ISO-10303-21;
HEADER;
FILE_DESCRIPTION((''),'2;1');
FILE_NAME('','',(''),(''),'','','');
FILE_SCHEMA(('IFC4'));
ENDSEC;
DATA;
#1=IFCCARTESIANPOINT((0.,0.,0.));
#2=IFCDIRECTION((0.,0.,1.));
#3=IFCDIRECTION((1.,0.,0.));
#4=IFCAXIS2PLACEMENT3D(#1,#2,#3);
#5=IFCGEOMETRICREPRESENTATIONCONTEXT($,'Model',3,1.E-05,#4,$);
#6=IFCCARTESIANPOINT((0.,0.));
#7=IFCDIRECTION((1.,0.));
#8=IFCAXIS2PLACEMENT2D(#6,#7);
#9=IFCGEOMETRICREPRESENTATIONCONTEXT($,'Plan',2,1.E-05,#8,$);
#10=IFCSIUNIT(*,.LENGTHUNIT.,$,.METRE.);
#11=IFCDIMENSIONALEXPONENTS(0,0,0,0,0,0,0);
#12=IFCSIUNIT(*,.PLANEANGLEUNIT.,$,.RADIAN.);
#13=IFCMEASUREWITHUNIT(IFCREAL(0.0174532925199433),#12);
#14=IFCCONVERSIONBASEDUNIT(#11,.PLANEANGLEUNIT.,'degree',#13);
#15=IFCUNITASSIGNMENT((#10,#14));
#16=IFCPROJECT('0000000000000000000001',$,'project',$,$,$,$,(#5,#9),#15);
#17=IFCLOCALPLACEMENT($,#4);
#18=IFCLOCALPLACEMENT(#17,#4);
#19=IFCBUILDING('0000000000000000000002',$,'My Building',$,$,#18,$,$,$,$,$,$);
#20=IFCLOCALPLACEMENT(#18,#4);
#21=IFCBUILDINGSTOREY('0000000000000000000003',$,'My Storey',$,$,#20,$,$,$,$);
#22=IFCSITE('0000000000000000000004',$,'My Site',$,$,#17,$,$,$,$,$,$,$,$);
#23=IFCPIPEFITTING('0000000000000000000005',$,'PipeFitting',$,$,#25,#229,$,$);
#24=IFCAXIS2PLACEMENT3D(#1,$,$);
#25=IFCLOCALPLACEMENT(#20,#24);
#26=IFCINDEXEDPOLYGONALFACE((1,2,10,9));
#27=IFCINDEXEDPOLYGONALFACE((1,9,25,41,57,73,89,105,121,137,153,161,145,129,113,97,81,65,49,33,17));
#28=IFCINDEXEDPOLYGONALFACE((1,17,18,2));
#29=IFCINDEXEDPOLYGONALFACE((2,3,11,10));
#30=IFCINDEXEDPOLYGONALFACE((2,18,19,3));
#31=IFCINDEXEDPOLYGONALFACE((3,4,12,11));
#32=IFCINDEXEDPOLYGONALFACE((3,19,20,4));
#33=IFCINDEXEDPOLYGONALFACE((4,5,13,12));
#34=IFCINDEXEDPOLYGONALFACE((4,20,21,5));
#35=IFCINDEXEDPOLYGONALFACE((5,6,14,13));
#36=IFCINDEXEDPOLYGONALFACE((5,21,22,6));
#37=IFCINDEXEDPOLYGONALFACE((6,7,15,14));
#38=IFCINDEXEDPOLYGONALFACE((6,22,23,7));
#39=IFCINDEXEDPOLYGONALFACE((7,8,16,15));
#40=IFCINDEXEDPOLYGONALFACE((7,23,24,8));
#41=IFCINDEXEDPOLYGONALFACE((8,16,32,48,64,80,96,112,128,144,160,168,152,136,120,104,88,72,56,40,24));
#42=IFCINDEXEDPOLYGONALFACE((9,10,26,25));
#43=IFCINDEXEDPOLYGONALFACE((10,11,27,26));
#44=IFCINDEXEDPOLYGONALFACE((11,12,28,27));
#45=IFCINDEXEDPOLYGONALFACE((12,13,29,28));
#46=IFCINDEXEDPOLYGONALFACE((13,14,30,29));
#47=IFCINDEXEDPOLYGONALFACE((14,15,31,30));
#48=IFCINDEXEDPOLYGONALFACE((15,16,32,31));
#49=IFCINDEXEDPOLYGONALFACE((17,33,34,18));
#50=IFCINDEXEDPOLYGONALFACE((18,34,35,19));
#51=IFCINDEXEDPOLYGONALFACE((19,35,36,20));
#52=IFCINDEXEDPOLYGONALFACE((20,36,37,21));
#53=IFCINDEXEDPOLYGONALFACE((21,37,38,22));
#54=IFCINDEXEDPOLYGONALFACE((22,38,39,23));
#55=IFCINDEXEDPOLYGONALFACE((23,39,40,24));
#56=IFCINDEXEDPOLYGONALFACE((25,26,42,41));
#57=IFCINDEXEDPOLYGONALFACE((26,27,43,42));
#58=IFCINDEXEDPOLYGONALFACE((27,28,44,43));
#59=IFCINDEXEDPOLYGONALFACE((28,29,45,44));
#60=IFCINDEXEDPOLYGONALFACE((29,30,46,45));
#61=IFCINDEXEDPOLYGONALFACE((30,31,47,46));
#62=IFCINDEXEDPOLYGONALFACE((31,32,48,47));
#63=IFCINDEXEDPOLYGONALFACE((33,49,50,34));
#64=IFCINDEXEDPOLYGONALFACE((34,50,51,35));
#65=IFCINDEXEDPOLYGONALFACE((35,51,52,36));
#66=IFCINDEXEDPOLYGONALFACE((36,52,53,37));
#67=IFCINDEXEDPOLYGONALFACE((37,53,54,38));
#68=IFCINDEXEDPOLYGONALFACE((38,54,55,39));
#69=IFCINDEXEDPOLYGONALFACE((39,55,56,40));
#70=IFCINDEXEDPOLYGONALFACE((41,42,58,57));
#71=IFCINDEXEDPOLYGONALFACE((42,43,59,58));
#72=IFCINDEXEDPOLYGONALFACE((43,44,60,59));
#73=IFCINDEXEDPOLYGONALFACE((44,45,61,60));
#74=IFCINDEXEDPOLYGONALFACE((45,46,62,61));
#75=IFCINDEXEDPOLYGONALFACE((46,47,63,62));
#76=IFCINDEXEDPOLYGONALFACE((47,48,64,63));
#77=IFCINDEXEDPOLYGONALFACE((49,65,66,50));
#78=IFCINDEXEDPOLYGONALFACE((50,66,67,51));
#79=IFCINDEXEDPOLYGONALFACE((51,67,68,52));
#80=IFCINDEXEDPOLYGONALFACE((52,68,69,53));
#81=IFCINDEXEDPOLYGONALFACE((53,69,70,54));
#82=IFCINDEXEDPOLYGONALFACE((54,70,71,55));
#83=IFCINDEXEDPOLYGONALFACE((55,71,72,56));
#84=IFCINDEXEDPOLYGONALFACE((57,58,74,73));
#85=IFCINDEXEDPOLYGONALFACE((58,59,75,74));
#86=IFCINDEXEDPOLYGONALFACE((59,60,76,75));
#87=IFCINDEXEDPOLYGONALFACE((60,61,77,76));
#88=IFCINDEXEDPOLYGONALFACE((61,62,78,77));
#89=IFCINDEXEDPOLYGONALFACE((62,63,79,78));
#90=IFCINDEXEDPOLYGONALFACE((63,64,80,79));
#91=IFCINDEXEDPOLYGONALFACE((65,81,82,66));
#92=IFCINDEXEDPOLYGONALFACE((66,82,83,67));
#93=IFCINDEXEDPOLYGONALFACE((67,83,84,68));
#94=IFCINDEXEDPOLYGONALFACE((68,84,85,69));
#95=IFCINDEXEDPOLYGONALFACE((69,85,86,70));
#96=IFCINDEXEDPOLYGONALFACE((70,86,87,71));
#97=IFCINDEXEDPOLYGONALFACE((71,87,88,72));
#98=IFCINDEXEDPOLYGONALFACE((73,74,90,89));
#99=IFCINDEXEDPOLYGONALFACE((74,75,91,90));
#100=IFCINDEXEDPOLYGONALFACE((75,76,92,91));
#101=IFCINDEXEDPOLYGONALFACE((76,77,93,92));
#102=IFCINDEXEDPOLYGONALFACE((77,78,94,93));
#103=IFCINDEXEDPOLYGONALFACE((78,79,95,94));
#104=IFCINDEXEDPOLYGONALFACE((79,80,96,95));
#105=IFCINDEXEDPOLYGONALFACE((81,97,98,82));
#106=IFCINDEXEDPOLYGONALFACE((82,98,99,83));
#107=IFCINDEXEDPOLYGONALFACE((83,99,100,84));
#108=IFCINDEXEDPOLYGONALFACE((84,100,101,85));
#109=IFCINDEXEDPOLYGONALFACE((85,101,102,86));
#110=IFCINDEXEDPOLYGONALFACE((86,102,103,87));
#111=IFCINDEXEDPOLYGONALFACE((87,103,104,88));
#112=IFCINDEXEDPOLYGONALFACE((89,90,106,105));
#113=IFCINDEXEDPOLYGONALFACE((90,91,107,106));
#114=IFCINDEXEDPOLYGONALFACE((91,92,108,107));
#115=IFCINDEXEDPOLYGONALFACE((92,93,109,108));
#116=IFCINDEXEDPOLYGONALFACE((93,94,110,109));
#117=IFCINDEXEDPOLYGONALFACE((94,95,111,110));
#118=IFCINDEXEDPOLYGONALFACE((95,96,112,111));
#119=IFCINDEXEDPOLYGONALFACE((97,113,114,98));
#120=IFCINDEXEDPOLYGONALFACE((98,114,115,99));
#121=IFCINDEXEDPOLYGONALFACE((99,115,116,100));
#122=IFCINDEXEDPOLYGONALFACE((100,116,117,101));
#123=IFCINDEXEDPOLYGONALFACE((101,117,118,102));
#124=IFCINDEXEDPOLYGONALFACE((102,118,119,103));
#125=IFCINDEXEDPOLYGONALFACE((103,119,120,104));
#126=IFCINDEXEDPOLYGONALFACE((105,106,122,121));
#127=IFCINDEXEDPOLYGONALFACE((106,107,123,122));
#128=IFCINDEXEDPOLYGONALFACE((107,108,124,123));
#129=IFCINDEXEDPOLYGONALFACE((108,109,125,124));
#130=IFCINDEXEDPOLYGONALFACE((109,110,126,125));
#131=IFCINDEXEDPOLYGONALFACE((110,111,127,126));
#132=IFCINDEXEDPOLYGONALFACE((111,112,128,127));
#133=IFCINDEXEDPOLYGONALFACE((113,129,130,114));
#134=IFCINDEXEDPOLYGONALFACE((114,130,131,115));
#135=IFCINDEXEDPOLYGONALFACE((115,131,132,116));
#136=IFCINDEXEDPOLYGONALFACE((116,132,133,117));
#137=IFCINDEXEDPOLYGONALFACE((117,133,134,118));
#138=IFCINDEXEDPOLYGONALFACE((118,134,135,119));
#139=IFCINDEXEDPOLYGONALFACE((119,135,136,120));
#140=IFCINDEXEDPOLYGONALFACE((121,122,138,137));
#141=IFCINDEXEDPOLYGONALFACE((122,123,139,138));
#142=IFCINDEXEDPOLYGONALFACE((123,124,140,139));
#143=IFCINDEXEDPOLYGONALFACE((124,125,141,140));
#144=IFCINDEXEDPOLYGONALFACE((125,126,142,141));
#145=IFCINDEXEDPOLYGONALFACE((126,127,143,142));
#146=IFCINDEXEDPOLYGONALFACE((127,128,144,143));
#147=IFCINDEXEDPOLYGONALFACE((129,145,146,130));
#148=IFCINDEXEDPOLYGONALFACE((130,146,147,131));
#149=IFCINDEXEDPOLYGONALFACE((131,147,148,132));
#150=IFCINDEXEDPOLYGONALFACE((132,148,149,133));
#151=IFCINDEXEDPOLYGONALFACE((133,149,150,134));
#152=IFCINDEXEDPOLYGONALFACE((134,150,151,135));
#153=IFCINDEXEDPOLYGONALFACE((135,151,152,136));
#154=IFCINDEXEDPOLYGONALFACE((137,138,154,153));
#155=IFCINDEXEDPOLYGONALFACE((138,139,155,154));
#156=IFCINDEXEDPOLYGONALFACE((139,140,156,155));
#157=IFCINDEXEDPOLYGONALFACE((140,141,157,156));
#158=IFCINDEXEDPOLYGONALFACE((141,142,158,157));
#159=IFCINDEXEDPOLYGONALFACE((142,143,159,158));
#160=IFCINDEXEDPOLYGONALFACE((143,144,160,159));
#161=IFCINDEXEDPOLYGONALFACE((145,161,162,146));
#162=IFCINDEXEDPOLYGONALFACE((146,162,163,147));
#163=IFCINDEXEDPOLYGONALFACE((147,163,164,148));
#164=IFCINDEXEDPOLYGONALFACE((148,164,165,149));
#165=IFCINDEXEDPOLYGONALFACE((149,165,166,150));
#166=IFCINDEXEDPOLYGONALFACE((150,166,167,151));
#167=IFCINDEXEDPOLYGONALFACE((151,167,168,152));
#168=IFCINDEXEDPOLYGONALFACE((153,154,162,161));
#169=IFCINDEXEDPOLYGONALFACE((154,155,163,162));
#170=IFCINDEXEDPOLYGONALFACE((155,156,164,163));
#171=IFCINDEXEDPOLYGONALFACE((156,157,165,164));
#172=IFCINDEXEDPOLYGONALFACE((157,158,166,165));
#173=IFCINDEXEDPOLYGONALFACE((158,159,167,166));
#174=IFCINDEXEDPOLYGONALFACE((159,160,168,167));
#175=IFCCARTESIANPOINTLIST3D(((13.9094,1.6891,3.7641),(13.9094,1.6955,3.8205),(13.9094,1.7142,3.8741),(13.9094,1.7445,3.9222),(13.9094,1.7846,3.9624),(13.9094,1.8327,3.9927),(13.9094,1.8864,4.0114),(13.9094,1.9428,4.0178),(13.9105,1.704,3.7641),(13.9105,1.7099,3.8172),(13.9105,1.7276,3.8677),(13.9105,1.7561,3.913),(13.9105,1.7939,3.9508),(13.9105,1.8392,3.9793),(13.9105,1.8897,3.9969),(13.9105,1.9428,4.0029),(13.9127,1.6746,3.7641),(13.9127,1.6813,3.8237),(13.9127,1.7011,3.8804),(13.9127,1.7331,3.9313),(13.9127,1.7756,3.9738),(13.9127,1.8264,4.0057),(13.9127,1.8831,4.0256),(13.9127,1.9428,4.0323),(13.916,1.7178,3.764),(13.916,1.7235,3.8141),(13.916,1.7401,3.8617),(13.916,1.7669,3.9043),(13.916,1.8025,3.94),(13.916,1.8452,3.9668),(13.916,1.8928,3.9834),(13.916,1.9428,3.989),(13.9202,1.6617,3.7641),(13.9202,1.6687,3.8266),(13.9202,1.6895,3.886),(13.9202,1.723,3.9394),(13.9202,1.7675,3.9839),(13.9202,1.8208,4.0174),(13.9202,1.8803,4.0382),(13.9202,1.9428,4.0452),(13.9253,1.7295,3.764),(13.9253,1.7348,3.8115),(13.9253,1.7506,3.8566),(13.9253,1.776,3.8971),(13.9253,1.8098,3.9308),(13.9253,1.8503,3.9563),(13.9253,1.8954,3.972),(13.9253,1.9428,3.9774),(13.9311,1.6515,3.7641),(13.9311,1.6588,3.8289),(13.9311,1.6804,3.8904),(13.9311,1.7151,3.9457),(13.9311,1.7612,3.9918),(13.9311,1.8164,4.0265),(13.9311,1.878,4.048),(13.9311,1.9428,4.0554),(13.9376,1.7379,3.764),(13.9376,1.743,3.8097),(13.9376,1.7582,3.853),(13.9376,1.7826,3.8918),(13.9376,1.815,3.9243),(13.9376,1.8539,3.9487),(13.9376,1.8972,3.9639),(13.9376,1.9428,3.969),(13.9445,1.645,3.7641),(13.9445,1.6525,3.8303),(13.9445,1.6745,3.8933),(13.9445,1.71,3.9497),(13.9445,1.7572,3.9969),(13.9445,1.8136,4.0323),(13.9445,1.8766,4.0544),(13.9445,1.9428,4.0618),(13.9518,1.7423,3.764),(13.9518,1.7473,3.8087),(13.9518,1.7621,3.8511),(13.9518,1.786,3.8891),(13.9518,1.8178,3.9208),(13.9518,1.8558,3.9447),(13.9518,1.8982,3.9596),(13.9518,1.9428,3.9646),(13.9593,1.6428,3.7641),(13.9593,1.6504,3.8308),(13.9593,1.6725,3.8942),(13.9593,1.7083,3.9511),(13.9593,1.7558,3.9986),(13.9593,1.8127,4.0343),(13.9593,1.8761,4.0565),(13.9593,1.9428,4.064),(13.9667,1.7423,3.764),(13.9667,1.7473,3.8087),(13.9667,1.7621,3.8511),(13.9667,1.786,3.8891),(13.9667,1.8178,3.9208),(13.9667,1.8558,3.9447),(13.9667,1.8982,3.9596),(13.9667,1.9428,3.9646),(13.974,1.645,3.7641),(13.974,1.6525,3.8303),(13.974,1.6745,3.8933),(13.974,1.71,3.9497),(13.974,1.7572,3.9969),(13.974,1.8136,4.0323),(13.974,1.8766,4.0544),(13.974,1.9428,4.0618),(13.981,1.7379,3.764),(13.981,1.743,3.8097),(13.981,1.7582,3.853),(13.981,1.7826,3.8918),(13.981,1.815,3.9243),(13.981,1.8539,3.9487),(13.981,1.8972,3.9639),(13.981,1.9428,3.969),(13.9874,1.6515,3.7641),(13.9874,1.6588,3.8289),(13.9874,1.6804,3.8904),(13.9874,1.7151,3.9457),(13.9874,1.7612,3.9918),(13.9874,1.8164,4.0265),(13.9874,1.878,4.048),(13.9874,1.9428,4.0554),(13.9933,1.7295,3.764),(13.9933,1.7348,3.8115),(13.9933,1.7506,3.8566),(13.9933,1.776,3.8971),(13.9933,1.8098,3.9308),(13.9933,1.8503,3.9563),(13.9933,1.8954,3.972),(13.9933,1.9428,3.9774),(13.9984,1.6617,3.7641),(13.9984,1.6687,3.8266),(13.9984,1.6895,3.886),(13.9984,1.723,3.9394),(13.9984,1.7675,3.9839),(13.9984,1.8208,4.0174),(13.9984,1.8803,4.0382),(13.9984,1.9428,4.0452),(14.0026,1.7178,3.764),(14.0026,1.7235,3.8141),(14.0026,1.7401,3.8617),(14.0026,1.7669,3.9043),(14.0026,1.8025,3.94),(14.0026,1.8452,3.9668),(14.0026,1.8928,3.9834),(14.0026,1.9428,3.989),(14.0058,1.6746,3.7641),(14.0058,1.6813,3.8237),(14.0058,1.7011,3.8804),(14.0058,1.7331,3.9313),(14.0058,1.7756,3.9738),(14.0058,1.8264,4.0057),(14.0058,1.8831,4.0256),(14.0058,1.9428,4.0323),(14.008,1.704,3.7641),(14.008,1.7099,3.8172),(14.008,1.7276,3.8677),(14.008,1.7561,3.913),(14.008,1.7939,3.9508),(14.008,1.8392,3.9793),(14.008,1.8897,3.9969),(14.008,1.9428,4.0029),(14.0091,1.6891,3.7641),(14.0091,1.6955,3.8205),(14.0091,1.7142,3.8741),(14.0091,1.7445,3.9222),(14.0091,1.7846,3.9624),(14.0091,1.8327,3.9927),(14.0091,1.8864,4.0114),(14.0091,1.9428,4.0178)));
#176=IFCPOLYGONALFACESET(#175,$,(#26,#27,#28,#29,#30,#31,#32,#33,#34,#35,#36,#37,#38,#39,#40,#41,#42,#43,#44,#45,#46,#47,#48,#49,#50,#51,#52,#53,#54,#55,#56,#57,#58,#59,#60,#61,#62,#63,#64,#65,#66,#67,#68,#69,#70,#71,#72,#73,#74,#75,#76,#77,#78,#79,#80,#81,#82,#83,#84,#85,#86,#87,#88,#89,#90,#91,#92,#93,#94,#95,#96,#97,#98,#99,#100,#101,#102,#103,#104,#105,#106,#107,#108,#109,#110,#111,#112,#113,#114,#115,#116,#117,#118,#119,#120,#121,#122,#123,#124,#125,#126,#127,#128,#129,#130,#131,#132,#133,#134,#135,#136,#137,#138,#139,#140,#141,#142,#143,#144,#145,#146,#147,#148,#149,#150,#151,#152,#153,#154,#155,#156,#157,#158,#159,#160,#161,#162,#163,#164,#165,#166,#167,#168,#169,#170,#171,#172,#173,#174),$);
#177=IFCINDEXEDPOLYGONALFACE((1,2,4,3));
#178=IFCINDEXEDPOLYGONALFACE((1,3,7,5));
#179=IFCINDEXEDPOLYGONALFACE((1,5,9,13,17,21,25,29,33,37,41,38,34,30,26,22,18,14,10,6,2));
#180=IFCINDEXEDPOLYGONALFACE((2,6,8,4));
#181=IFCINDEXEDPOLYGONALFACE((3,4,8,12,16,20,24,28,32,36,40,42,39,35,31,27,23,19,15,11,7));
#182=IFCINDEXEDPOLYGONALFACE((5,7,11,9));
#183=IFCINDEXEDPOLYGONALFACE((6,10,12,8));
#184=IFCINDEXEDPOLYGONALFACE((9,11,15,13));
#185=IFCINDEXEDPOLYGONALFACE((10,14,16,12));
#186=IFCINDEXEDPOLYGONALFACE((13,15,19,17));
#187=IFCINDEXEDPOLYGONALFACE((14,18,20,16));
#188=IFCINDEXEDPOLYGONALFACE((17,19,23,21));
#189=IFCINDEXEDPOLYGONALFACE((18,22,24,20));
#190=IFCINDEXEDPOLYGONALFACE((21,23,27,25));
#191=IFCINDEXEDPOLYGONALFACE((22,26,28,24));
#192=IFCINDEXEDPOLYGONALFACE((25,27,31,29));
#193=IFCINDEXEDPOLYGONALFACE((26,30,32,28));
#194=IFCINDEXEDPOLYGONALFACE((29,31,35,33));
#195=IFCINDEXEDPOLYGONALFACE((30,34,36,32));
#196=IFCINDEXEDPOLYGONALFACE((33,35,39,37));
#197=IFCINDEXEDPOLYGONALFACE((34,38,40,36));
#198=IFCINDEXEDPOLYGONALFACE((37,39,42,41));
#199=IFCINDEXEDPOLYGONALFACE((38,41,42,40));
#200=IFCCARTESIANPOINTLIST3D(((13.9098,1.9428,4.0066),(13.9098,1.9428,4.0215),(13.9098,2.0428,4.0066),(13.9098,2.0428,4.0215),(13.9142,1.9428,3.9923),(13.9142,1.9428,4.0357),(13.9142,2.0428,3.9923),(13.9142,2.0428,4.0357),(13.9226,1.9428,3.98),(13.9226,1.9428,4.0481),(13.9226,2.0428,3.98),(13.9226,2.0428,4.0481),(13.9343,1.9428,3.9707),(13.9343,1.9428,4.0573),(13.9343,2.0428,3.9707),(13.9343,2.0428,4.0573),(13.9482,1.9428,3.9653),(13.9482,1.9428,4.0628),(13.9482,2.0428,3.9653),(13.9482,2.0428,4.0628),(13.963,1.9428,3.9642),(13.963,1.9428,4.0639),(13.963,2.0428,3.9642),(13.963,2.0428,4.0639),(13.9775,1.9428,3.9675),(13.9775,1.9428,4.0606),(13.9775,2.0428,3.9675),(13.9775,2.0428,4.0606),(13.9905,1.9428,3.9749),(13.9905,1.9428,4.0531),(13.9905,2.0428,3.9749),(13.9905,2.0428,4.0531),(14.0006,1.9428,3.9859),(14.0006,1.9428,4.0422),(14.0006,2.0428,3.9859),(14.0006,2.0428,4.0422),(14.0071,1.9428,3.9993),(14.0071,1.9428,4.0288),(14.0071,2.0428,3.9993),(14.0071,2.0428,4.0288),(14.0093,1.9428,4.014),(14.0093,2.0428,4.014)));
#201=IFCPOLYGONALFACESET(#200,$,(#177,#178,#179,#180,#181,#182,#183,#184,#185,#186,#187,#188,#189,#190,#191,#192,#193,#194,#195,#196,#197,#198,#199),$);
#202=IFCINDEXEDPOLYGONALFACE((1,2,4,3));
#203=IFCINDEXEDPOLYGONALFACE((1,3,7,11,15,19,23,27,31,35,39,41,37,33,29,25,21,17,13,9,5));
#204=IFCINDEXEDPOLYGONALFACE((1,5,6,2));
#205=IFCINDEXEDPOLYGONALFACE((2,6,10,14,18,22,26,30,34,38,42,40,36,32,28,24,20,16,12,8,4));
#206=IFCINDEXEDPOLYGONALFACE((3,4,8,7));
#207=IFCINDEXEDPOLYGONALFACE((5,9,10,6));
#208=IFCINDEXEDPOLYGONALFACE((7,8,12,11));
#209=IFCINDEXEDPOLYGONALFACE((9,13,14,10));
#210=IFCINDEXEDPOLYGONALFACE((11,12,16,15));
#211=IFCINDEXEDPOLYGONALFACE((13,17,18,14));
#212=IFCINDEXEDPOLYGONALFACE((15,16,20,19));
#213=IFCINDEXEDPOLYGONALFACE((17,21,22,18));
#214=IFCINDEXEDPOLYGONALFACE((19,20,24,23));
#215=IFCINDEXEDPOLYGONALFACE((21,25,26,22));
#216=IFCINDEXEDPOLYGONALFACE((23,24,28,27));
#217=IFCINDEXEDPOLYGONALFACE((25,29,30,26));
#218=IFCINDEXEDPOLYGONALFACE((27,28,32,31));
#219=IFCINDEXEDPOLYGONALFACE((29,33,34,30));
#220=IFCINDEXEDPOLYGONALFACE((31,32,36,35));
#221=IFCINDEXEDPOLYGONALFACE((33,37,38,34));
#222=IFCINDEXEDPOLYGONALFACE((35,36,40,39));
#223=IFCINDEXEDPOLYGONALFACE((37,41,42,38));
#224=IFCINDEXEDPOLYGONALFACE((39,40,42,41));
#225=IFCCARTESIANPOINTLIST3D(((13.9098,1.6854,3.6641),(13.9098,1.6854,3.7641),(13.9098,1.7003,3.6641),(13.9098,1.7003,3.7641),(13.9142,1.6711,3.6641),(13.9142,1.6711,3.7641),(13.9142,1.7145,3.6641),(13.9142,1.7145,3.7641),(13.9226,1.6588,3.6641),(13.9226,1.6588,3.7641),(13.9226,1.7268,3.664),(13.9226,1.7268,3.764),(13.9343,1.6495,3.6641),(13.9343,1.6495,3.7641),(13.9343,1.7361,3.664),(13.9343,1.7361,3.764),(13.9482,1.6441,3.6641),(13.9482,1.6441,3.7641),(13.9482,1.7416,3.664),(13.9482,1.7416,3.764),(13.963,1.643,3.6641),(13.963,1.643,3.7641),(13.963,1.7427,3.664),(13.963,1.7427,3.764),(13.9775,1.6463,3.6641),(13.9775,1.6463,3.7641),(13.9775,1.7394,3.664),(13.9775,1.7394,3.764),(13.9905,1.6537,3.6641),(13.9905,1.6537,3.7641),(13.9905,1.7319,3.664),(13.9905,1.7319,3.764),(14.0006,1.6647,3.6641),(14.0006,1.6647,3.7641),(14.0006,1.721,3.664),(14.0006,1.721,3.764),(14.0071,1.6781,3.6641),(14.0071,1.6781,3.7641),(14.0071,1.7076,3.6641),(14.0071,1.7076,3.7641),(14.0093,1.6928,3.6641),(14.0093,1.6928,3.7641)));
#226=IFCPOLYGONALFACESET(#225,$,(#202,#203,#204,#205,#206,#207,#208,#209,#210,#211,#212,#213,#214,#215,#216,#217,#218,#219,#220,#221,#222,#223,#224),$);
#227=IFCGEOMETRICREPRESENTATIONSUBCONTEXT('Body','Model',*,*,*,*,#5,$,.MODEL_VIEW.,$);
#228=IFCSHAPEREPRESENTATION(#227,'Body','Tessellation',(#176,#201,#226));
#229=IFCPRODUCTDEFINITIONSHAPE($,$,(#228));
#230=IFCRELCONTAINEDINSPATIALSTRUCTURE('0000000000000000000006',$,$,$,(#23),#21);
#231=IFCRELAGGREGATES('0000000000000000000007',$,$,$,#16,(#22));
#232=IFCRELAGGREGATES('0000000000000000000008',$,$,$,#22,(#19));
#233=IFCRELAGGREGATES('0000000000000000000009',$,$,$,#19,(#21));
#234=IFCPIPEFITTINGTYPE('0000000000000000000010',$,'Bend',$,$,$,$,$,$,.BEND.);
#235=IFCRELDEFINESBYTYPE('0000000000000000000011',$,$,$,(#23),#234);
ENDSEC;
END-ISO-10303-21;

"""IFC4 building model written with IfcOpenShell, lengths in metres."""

from ifc_helpers import new_model, entity, si_unit, converted_unit, frame, origin_with_axes, origin_2d_with_axis, place, context, subcontext, project, spatial, circle, extrude, source, transform, mapped, type_object, type_shapes, element, save


model = new_model("IFC4")

# Units and contexts
model_context = context("Model", 3, precision=1e-05, world=origin_with_axes())
plan_context = context("Plan", 2, precision=1e-05, world=origin_2d_with_axis())
body_context_1 = subcontext(model_context, "Body", "Model", "MODEL_VIEW")
ifc_project = project(units=[si_unit("LENGTHUNIT", "METRE"), converted_unit("PLANEANGLEUNIT", "degree", entity("IfcReal", 0.0174532925199433), si_unit("PLANEANGLEUNIT", "RADIAN"), dimensions=[0, 0, 0, 0, 0, 0, 0])], contexts=[model_context, plan_context])

# Site, building, storey
site_placement = place(None, origin_with_axes())
site = spatial("IfcSite", under=ifc_project, at=site_placement, Name="My Site")
building_placement = place(site_placement, origin_with_axes())
building = spatial("IfcBuilding", under=site, at=building_placement, Name="My Building")
storey_placement = place(building_placement, origin_with_axes())
storey = spatial("IfcBuildingStorey", under=building, at=storey_placement, Name="My Storey")

# Pipe fitting
pipe_fitting_type_1 = type_object("IfcPipeFittingType", Name="Bend", PredefinedType="BEND")
shared_shape_1 = source(origin_with_axes(), body_context_1, "Body", "SolidModel", [
    entity("IfcSweptDiskSolid", entity("IfcIndexedPolyCurve", entity("IfcCartesianPointList3D", [[0.0, 0.0, 0.1], [0.0, -0.0732, 0.2768], [0.0, -0.25, 0.35]]), [entity("IfcArcIndex", [1, 2, 3])]), 0.05),
    extrude(circle(Radius=0.05), origin_with_axes(), (0.0, 0.0, 1.0), 0.1),
    extrude(circle(Radius=0.05), frame((0.0, -0.25, 0.35), z_axis=(0.0, -1.0, 0.000038), x_axis=(1.0, 0.0, 0.0)), (0.0, 0.0, 1.0), 0.1),
])
type_shapes(pipe_fitting_type_1, [shared_shape_1])
for number, where, z_axis, x_axis, name in (
    (1, (13.9593, 2.0428, 4.014), (0.0, -1.0, 0.0), (1.0, 0.0, 0.0), "PipeFitting"),
):
    element("IfcPipeFitting", number, at=place(storey_placement, frame(where, z_axis=z_axis, x_axis=x_axis)), inside=storey, type_object=pipe_fitting_type_1, Name=name, context=body_context_1, shape_type="MappedRepresentation", body=[
        mapped(shared_shape_1, transform((0.0, 0.0, 0.0), x_axis=(1.0, 0.0, 0.0), y_axis=(0.0, 1.0, 0.0), z_axis=(0.0, 0.0, 1.0), scale=1.0)),
    ])

save(model, "model.ifc")
